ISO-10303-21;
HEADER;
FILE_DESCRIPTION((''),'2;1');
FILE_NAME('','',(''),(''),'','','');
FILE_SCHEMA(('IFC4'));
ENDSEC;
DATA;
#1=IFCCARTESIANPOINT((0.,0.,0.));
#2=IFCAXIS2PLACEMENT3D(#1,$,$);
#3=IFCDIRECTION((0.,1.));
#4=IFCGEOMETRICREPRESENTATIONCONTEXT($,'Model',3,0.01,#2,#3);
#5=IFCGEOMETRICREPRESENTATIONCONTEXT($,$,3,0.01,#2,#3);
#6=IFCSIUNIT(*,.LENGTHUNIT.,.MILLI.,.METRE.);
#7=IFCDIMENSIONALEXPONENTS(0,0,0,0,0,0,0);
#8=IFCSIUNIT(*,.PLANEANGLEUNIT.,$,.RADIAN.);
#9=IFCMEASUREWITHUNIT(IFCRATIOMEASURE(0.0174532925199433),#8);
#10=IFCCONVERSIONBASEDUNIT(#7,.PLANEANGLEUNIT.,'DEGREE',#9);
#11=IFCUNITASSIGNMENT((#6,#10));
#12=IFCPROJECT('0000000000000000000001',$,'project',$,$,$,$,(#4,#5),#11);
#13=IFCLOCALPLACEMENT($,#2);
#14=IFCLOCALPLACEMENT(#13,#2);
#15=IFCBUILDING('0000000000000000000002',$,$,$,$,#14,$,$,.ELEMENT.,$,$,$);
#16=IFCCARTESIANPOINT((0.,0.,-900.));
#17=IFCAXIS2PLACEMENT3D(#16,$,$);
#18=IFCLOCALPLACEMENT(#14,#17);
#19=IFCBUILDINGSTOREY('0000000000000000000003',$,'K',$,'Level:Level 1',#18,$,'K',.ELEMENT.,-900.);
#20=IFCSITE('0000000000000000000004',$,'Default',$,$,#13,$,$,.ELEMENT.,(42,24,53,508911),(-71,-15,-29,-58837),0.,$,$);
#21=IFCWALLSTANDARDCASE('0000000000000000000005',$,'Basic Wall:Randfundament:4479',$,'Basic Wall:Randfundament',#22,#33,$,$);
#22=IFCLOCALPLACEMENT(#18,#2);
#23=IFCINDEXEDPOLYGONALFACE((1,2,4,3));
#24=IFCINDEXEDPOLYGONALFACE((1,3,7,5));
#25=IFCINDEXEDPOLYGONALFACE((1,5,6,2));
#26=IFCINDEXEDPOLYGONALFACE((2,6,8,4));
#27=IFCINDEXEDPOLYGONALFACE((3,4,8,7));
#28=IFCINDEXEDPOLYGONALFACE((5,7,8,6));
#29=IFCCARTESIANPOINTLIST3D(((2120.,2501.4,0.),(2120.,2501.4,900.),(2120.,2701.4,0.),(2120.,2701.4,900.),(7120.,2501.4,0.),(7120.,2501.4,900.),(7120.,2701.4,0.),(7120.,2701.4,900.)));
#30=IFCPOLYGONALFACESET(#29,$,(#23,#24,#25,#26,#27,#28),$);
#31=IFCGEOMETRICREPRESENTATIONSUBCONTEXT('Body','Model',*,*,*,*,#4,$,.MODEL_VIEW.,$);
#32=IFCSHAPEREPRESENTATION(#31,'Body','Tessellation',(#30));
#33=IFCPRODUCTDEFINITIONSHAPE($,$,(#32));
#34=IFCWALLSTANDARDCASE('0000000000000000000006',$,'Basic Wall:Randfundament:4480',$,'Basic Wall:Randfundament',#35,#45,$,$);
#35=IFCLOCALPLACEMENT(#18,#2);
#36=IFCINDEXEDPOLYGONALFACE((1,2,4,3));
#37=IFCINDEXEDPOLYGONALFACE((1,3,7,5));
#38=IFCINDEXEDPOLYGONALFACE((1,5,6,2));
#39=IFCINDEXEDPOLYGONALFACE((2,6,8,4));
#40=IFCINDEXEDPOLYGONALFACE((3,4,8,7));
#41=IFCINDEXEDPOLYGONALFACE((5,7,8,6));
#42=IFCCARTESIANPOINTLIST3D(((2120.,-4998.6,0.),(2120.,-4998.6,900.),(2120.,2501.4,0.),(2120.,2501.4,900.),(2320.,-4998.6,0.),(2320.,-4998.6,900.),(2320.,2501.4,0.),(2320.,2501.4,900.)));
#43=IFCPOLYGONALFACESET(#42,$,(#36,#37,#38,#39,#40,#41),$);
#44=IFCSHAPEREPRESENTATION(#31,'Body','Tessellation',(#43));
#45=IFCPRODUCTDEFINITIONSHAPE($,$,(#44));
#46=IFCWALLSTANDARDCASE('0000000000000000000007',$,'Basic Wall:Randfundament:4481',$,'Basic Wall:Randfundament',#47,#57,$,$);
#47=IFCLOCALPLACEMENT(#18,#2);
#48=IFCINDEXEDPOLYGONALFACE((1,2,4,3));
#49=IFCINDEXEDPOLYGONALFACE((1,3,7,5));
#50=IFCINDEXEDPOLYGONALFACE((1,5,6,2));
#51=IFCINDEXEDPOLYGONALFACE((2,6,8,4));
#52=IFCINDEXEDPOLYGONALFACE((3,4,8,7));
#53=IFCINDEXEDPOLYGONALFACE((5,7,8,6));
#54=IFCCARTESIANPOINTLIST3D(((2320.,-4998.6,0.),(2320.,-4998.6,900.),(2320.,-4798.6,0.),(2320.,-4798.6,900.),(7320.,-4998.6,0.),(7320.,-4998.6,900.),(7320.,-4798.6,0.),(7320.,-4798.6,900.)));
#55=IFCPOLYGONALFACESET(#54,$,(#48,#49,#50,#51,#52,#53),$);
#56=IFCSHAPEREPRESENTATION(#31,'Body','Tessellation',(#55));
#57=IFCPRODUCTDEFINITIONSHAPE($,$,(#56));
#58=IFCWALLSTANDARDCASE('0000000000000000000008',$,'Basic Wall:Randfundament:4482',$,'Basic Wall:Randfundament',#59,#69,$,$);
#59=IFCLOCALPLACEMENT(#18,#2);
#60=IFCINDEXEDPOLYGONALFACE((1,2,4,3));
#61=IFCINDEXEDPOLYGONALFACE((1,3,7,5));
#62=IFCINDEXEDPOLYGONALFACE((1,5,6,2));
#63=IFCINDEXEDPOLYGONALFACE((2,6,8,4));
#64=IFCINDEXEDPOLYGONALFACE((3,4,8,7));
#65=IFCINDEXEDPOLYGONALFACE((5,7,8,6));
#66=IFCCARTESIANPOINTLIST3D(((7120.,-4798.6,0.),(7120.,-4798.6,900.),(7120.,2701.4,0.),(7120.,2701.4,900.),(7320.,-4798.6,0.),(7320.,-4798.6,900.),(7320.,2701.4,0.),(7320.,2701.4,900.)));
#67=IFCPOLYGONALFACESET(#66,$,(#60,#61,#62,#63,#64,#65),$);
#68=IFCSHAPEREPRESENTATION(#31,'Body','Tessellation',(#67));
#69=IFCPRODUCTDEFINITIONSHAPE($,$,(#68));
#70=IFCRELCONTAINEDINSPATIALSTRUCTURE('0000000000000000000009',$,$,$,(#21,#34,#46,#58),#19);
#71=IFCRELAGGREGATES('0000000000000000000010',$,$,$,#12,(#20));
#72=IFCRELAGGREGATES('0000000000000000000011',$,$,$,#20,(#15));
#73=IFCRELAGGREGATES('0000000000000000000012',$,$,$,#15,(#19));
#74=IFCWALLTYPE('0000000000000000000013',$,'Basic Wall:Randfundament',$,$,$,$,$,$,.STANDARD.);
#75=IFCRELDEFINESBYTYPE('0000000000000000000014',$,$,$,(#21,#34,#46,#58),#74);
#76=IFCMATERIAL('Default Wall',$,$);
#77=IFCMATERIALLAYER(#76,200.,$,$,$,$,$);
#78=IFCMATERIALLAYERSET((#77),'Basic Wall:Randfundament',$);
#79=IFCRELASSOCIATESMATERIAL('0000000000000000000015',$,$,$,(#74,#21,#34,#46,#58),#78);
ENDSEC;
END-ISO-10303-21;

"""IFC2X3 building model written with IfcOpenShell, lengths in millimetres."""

from ifc_helpers import new_model, entity, si_unit, converted_unit, direction, frame, frame_2d, origin, place, context, subcontext, project, spatial, rectangle, extrude, material, layer, layer_set, layer_usage, type_object, element, save


model = new_model("IFC2X3")

# Units and contexts
model_context = context("Model", 3, precision=0.01, world=origin(), true_north=direction((0.0, 1.0)))
context_of_model = context(None, 3, precision=0.01, world=origin(), true_north=direction((0.0, 1.0)))
body_context = subcontext(model_context, "Body", "Model", "MODEL_VIEW")
ifc_project = project(units=[si_unit("LENGTHUNIT", "METRE", prefix="MILLI"), converted_unit("PLANEANGLEUNIT", "DEGREE", entity("IfcRatioMeasure", 0.0174532925199433), si_unit("PLANEANGLEUNIT", "RADIAN"), dimensions=[0, 0, 0, 0, 0, 0, 0])], contexts=[model_context, context_of_model])

# Site, building, storey
site_placement = place(None, origin())
site = spatial("IfcSite", under=ifc_project, at=site_placement, Name="Default", CompositionType="ELEMENT", RefLatitude=(42, 24, 53, 508911), RefLongitude=(-71, -15, -29, -58837), RefElevation=0.0)
building_placement = place(site_placement, origin())
building = spatial("IfcBuilding", under=site, at=building_placement, CompositionType="ELEMENT")
storey_placement = place(building_placement, frame((0.0, 0.0, -900.0)))
storey = spatial("IfcBuildingStorey", under=building, at=storey_placement, Name="K", ObjectType="Level:Level 1", LongName="K", CompositionType="ELEMENT", Elevation=-900.0)

# Walls
ifc_material = material(Name="Default Wall")
ifc_layer = layer(ifc_material, 200.0)
ifc_layer_set = layer_set([ifc_layer], Name="Basic Wall:Randfundament")
ifc_layer_usage_1 = layer_usage(ifc_layer_set, "AXIS2", "NEGATIVE", 100.0)
wall_type = type_object("IfcWallType", Name="Basic Wall:Randfundament", PredefinedType="STANDARD", material=ifc_layer_set)
wall_1_placement = place(storey_placement, frame((2120.0, 2601.4, 0.0)))
element("IfcWallStandardCase", 1, at=wall_1_placement, inside=storey, type_object=wall_type, material=ifc_layer_usage_1, Name="Basic Wall:Randfundament:4479", ObjectType="Basic Wall:Randfundament", context=body_context, shape_type="SweptSolid", body=[
    extrude(rectangle(XDim=5000.0, YDim=200.0, at=frame_2d((2500.0, 0.0), x_axis=(-1.0, 0.0))), origin(), (0.0, 0.0, 1.0), 900.0),
])
ifc_layer_usage_2 = layer_usage(ifc_layer_set, "AXIS2", "NEGATIVE", 100.0)
wall_2_placement = place(storey_placement, frame((2220.0, -4998.6, 0.0), z_axis=(0.0, 0.0, 1.0), x_axis=(0.0, 1.0, 0.0)))
element("IfcWallStandardCase", 2, at=wall_2_placement, inside=storey, type_object=wall_type, material=ifc_layer_usage_2, Name="Basic Wall:Randfundament:4480", ObjectType="Basic Wall:Randfundament", context=body_context, shape_type="SweptSolid", body=[
    extrude(rectangle(XDim=7500.0, YDim=200.0, at=frame_2d((3750.0, 0.0), x_axis=(-1.0, 0.0))), origin(), (0.0, 0.0, 1.0), 900.0),
])
ifc_layer_usage_3 = layer_usage(ifc_layer_set, "AXIS2", "NEGATIVE", 100.0)
wall_3_placement = place(storey_placement, frame((7320.0, -4898.6, 0.0), z_axis=(0.0, 0.0, 1.0), x_axis=(-1.0, 0.0, 0.0)))
element("IfcWallStandardCase", 3, at=wall_3_placement, inside=storey, type_object=wall_type, material=ifc_layer_usage_3, Name="Basic Wall:Randfundament:4481", ObjectType="Basic Wall:Randfundament", context=body_context, shape_type="SweptSolid", body=[
    extrude(rectangle(XDim=5000.0, YDim=200.0, at=frame_2d((2500.0, 0.0), x_axis=(-1.0, 0.0))), origin(), (0.0, 0.0, 1.0), 900.0),
])
ifc_layer_usage_4 = layer_usage(ifc_layer_set, "AXIS2", "NEGATIVE", 100.0)
wall_4_placement = place(storey_placement, frame((7220.0, 2701.4, 0.0), z_axis=(0.0, 0.0, 1.0), x_axis=(0.0, -1.0, 0.0)))
element("IfcWallStandardCase", 4, at=wall_4_placement, inside=storey, type_object=wall_type, material=ifc_layer_usage_4, Name="Basic Wall:Randfundament:4482", ObjectType="Basic Wall:Randfundament", context=body_context, shape_type="SweptSolid", body=[
    extrude(rectangle(XDim=7500.0, YDim=200.0, at=frame_2d((3750.0, 0.0), x_axis=(-1.0, 0.0))), origin(), (0.0, 0.0, 1.0), 900.0),
])

save(model, "model.ifc")
